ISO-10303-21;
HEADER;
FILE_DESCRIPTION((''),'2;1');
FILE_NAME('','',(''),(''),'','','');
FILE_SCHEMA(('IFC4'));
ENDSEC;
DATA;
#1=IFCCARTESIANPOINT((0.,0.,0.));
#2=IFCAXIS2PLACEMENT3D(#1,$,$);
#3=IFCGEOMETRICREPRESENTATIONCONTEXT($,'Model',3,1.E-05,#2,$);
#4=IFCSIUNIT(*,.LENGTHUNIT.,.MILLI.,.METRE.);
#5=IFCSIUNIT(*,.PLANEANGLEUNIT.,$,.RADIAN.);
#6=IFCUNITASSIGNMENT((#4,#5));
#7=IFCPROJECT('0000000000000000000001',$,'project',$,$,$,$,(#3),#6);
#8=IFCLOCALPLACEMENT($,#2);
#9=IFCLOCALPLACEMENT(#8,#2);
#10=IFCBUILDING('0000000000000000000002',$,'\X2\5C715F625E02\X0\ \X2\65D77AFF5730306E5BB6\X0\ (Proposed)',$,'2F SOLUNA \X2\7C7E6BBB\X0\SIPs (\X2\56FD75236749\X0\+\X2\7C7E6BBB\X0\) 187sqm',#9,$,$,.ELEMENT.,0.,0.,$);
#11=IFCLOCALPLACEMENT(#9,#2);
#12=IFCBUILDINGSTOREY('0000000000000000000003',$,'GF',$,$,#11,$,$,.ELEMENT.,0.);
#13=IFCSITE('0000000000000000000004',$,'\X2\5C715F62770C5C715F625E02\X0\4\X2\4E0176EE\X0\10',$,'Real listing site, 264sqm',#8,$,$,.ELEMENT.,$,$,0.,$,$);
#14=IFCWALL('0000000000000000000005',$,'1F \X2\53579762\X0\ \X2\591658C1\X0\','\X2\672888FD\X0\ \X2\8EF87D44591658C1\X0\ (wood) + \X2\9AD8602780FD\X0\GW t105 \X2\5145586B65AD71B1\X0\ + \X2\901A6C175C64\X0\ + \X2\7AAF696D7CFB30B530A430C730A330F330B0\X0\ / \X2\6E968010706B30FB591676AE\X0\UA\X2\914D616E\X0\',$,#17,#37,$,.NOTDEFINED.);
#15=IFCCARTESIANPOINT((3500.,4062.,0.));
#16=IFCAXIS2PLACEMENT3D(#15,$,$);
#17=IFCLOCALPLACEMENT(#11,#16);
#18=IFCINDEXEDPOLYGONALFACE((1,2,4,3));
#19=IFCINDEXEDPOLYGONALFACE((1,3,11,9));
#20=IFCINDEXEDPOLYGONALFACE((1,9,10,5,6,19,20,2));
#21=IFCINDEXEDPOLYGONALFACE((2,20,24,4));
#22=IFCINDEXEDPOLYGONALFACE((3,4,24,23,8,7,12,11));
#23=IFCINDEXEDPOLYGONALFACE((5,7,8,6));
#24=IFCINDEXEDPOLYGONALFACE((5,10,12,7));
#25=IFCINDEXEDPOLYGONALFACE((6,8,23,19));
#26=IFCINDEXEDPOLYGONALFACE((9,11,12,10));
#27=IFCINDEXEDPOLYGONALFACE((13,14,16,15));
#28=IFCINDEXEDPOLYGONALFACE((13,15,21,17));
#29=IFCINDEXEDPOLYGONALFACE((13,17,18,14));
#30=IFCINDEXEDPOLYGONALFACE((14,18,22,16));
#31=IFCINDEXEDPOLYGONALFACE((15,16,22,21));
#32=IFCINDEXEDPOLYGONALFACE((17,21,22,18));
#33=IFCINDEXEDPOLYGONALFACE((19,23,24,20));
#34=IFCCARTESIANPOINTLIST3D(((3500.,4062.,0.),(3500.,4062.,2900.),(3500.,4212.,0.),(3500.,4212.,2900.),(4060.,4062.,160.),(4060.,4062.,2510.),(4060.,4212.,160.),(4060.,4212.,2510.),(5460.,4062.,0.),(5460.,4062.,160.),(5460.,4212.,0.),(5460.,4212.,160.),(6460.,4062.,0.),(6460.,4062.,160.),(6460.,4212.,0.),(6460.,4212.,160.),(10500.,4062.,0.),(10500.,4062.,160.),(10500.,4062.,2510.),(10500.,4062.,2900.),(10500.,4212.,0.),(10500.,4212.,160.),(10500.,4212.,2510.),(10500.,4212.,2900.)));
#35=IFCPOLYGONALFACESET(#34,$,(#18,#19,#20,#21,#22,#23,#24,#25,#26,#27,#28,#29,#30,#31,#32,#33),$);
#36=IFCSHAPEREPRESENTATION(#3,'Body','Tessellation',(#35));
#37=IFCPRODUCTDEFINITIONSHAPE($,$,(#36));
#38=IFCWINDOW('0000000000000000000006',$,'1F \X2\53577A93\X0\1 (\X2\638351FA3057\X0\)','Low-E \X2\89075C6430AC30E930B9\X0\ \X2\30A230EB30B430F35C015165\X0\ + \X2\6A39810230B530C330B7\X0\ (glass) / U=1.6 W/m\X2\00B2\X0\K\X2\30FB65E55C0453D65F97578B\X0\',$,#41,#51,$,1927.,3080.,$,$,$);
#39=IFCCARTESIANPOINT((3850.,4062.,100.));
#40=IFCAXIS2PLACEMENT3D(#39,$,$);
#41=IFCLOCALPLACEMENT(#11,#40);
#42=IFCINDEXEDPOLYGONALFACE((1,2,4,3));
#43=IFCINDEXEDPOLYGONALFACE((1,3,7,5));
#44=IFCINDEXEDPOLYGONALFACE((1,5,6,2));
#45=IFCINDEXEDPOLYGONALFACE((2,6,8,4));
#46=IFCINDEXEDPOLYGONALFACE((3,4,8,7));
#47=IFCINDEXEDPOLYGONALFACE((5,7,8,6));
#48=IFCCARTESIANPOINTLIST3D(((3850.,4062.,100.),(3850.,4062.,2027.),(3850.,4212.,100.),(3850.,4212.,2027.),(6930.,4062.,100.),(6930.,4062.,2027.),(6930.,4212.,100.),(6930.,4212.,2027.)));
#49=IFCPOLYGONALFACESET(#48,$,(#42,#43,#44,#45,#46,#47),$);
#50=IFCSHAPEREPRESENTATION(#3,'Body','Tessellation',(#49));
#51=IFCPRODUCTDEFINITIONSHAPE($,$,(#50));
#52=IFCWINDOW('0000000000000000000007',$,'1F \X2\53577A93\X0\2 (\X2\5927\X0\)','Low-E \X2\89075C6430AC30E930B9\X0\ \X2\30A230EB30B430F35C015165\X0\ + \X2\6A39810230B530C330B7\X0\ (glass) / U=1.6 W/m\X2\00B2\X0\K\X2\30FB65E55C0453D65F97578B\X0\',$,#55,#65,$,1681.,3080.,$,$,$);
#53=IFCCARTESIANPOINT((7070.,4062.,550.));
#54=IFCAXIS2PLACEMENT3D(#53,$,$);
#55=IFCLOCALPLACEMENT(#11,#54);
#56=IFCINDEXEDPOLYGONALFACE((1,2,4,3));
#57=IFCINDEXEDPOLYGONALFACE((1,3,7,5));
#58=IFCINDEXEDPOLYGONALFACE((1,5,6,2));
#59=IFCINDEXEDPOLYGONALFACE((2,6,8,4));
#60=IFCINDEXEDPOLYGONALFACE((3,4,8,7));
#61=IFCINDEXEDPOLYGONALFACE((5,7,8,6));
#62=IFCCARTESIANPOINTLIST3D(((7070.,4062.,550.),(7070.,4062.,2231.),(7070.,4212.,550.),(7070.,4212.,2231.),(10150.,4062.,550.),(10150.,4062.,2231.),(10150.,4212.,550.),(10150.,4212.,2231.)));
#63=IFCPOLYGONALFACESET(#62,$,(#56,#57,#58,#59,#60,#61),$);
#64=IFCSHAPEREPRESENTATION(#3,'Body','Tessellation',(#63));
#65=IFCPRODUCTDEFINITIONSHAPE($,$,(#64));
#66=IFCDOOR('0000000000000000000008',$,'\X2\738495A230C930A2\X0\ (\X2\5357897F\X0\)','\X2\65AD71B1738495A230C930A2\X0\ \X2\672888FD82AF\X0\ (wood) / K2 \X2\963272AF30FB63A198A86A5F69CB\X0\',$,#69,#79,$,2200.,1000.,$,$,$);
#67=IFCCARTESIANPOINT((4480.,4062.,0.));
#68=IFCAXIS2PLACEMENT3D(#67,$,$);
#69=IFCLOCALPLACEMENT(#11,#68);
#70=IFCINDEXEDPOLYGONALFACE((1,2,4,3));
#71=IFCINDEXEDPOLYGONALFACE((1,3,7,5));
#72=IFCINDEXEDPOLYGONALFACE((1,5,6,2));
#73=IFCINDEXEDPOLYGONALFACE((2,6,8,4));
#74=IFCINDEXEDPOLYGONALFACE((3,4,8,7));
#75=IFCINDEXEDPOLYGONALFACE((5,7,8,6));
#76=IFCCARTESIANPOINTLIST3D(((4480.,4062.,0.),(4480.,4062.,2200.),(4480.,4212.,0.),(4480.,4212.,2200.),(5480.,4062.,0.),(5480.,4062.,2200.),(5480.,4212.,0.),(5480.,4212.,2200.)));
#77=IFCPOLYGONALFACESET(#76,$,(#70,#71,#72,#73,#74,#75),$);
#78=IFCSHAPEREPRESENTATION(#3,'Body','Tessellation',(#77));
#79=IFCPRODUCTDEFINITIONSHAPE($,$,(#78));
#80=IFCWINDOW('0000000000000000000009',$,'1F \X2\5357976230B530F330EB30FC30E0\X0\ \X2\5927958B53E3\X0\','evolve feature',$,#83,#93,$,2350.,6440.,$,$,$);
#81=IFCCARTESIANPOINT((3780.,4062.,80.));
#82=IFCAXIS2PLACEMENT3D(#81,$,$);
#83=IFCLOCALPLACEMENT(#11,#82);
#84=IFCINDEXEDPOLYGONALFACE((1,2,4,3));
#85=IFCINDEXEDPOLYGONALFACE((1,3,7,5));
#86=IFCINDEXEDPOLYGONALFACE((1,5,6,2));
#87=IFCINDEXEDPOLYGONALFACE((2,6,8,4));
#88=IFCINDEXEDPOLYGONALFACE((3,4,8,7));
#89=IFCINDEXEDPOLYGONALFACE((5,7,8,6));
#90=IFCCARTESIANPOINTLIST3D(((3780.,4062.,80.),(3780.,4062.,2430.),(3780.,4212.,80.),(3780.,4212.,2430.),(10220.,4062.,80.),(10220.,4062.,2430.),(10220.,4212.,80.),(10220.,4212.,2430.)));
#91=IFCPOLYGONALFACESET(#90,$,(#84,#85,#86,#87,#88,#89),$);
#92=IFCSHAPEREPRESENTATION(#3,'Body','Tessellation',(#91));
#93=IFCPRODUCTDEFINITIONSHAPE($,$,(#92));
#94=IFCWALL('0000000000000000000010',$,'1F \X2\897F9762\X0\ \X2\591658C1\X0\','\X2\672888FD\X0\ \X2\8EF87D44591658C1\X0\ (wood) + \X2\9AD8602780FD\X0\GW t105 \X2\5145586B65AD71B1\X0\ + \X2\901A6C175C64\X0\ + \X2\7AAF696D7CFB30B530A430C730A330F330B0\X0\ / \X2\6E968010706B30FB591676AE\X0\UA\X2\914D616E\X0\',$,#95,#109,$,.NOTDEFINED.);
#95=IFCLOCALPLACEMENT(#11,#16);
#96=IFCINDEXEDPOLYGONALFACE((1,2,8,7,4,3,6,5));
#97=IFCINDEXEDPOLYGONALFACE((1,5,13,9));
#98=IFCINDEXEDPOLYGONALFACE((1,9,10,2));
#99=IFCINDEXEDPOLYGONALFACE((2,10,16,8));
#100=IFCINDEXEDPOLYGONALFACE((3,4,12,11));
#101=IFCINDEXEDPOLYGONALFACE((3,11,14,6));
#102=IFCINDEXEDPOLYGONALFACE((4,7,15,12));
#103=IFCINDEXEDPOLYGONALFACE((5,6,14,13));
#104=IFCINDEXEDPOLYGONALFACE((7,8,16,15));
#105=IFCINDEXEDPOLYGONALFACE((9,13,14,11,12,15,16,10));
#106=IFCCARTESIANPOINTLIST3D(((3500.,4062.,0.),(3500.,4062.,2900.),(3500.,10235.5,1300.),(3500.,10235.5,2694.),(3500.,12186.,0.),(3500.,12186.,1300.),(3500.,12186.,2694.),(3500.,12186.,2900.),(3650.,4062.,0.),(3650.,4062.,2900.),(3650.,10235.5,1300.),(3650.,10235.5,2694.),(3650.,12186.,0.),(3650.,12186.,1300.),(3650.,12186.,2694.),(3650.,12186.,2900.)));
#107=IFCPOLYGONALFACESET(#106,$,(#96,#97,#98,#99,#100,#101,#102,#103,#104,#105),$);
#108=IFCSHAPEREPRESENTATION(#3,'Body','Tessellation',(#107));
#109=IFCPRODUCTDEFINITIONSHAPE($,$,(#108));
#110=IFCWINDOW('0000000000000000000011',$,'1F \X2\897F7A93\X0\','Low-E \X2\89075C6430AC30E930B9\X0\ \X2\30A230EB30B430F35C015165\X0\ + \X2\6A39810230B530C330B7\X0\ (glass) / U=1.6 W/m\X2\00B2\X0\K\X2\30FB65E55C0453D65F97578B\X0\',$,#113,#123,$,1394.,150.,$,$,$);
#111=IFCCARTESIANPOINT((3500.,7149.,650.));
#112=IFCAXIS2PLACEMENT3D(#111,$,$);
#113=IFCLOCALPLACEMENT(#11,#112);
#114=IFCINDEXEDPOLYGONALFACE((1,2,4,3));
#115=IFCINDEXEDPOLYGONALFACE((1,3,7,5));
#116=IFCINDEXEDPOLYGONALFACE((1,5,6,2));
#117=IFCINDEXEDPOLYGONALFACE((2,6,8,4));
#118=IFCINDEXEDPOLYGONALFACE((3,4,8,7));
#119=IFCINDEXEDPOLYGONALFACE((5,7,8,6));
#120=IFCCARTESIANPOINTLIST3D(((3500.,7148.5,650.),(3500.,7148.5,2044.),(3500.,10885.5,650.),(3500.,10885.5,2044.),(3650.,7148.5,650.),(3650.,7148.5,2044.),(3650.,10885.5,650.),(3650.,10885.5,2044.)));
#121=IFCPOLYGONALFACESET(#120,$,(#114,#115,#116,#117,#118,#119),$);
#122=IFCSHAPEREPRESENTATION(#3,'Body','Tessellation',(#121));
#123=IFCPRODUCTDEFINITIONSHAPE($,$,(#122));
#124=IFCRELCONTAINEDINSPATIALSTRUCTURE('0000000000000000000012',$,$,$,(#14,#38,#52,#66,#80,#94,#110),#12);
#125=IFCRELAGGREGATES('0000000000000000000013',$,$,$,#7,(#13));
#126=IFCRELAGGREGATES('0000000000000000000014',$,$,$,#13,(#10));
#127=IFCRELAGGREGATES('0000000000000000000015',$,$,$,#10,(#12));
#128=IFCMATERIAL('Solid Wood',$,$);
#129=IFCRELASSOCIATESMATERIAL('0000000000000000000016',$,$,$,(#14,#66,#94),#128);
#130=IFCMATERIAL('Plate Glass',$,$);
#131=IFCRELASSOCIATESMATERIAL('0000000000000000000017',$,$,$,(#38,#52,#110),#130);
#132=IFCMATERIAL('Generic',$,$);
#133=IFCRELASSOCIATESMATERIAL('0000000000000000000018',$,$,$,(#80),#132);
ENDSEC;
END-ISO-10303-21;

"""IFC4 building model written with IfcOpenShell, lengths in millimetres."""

from ifc_helpers import new_model, si_unit, frame, frame_2d, origin, place, context, project, spatial, rectangle, extrude, material, element, fill, save


model = new_model("IFC4")

# Units and contexts
model_context = context("Model", 3, precision=1e-05, world=origin())
ifc_project = project(units=[si_unit("LENGTHUNIT", "METRE", prefix="MILLI"), si_unit("PLANEANGLEUNIT", "RADIAN")], contexts=[model_context])

# Site, building, storey
site_placement = place(None, origin())
site = spatial("IfcSite", under=ifc_project, at=site_placement, Name="山形県山形市4丁目10", ObjectType="Real listing site, 264sqm", CompositionType="ELEMENT", RefElevation=0.0)
building_placement = place(site_placement, origin())
building = spatial("IfcBuilding", under=site, at=building_placement, Name="山形市 旗竿地の家 (Proposed)", ObjectType="2F SOLUNA 籾殻SIPs (国産杉+籾殻) 187sqm", CompositionType="ELEMENT", ElevationOfRefHeight=0.0, ElevationOfTerrain=0.0)
storey_placement = place(building_placement, origin())
storey = spatial("IfcBuildingStorey", under=building, at=storey_placement, Name="GF", CompositionType="ELEMENT", Elevation=0.0)

# Shared definitions
ifc_material_1 = material(Name="Solid Wood")
ifc_material_2 = material(Name="Generic")

# Wall, openings, windows, door
wall_1_placement = place(storey_placement, frame((3500.0, 4062.0, 0.0)))
wall_1 = element("IfcWall", 1, at=wall_1_placement, inside=storey, material=ifc_material_1, Name="1F 南面 外壁", Description="木製 軸組外壁 (wood) + 高性能GW t105 充填断熱 + 通気層 + 窯業系サイディング / 準耐火・外皮UA配慮", PredefinedType="NOTDEFINED", context=model_context, shape_type="SweptSolid", body=[
    extrude(rectangle(XDim=7000.0, YDim=150.0, at=frame_2d((3500.0, 75.0))), frame((3500.0, 4062.0, 0.0)), (0.0, 0.0, 1.0), 2900.0),
])
opening_1_placement = place(storey_placement, frame((3850.0, 4062.0, 100.0)))
opening_1 = element("IfcOpeningElement", 2, at=opening_1_placement, cuts=wall_1, PredefinedType="NOTDEFINED", context=model_context, shape_type="SweptSolid", body=[
    extrude(rectangle(XDim=3080.0, YDim=150.0, at=frame_2d((1540.0, 75.0))), frame((3850.0, 4062.0, 100.0)), (0.0, 0.0, 1.0), 1927.0),
])
opening_2_placement = place(storey_placement, frame((7070.0, 4062.0, 550.0)))
opening_2 = element("IfcOpeningElement", 3, at=opening_2_placement, cuts=wall_1, PredefinedType="NOTDEFINED", context=model_context, shape_type="SweptSolid", body=[
    extrude(rectangle(XDim=3080.0, YDim=150.0, at=frame_2d((1540.0, 75.0))), frame((7070.0, 4062.0, 550.0)), (0.0, 0.0, 1.0), 1681.0),
])
opening_3_placement = place(storey_placement, frame((4480.0, 4062.0, 0.0)))
opening_3 = element("IfcOpeningElement", 4, at=opening_3_placement, cuts=wall_1, PredefinedType="NOTDEFINED", context=model_context, shape_type="SweptSolid", body=[
    extrude(rectangle(XDim=1000.0, YDim=150.0, at=frame_2d((500.0, 75.0))), frame((4480.0, 4062.0, 0.0)), (0.0, 0.0, 1.0), 2200.0),
])
opening_4_placement = place(storey_placement, frame((3780.0, 4062.0, 80.0)))
opening_4 = element("IfcOpeningElement", 5, at=opening_4_placement, cuts=wall_1, PredefinedType="NOTDEFINED", context=model_context, shape_type="SweptSolid", body=[
    extrude(rectangle(XDim=6440.0, YDim=150.0, at=frame_2d((3220.0, 75.0))), frame((3780.0, 4062.0, 80.0)), (0.0, 0.0, 1.0), 2350.0),
])
ifc_material_3 = material(Name="Plate Glass")
window_1_placement = place(storey_placement, frame((3850.0, 4062.0, 100.0)))
window_1 = element("IfcWindow", 6, at=window_1_placement, inside=storey, material=ifc_material_3, Name="1F 南窓1 (掃出し)", Description="Low-E 複層ガラス アルゴン封入 + 樹脂サッシ (glass) / U=1.6 W/m²K・日射取得型", OverallHeight=1927.0, OverallWidth=3080.0, context=model_context, shape_type="SweptSolid", body=[
    extrude(rectangle(XDim=3080.0, YDim=150.0, at=frame_2d((1540.0, 75.0))), frame((3850.0, 4062.0, 100.0)), (0.0, 0.0, 1.0), 1927.0),
])
fill(opening_1, window_1)
window_2_placement = place(storey_placement, frame((7070.0, 4062.0, 550.0)))
window_2 = element("IfcWindow", 7, at=window_2_placement, inside=storey, material=ifc_material_3, Name="1F 南窓2 (大)", Description="Low-E 複層ガラス アルゴン封入 + 樹脂サッシ (glass) / U=1.6 W/m²K・日射取得型", OverallHeight=1681.0, OverallWidth=3080.0, context=model_context, shape_type="SweptSolid", body=[
    extrude(rectangle(XDim=3080.0, YDim=150.0, at=frame_2d((1540.0, 75.0))), frame((7070.0, 4062.0, 550.0)), (0.0, 0.0, 1.0), 1681.0),
])
fill(opening_2, window_2)
door_placement = place(storey_placement, frame((4480.0, 4062.0, 0.0)))
door = element("IfcDoor", 8, at=door_placement, inside=storey, material=ifc_material_1, Name="玄関ドア (南西)", Description="断熱玄関ドア 木製芯 (wood) / K2 防犯・採風機構", OverallHeight=2200.0, OverallWidth=1000.0, context=model_context, shape_type="SweptSolid", body=[
    extrude(rectangle(XDim=1000.0, YDim=150.0, at=frame_2d((500.0, 75.0))), frame((4480.0, 4062.0, 0.0)), (0.0, 0.0, 1.0), 2200.0),
])
fill(opening_3, door)
window_3_placement = place(storey_placement, frame((3780.0, 4062.0, 80.0)))
window_3 = element("IfcWindow", 9, at=window_3_placement, inside=storey, material=ifc_material_2, Name="1F 南面サンルーム 大開口", Description="evolve feature", OverallHeight=2350.0, OverallWidth=6440.0, context=model_context, shape_type="SweptSolid", body=[
    extrude(rectangle(XDim=6440.0, YDim=150.0, at=frame_2d((3220.0, 75.0))), frame((3780.0, 4062.0, 80.0)), (0.0, 0.0, 1.0), 2350.0),
])
fill(opening_4, window_3)

# Wall, opening, window
wall_2_placement = place(storey_placement, frame((3500.0, 4062.0, 0.0)))
wall_2 = element("IfcWall", 10, at=wall_2_placement, inside=storey, material=ifc_material_1, Name="1F 西面 外壁", Description="木製 軸組外壁 (wood) + 高性能GW t105 充填断熱 + 通気層 + 窯業系サイディング / 準耐火・外皮UA配慮", PredefinedType="NOTDEFINED", context=model_context, shape_type="SweptSolid", body=[
    extrude(rectangle(XDim=150.0, YDim=8124.0, at=frame_2d((75.0, 4062.0))), frame((3500.0, 4062.0, 0.0)), (0.0, 0.0, 1.0), 2900.0),
])
opening_5_placement = place(storey_placement, frame((3500.0, 7149.0, 650.0)))
opening_5 = element("IfcOpeningElement", 11, at=opening_5_placement, cuts=wall_2, PredefinedType="NOTDEFINED", context=model_context, shape_type="SweptSolid", body=[
    extrude(rectangle(XDim=150.0, YDim=3737.0, at=frame_2d((75.0, 1868.0))), frame((3500.0, 7149.0, 650.0)), (0.0, 0.0, 1.0), 1394.0),
])
window_4_placement = place(storey_placement, frame((3500.0, 7149.0, 650.0)))
window_4 = element("IfcWindow", 12, at=window_4_placement, inside=storey, material=ifc_material_3, Name="1F 西窓", Description="Low-E 複層ガラス アルゴン封入 + 樹脂サッシ (glass) / U=1.6 W/m²K・日射取得型", OverallHeight=1394.0, OverallWidth=150.0, context=model_context, shape_type="SweptSolid", body=[
    extrude(rectangle(XDim=150.0, YDim=3737.0, at=frame_2d((75.0, 1868.0))), frame((3500.0, 7149.0, 650.0)), (0.0, 0.0, 1.0), 1394.0),
])
fill(opening_5, window_4)

save(model, "model.ifc")
